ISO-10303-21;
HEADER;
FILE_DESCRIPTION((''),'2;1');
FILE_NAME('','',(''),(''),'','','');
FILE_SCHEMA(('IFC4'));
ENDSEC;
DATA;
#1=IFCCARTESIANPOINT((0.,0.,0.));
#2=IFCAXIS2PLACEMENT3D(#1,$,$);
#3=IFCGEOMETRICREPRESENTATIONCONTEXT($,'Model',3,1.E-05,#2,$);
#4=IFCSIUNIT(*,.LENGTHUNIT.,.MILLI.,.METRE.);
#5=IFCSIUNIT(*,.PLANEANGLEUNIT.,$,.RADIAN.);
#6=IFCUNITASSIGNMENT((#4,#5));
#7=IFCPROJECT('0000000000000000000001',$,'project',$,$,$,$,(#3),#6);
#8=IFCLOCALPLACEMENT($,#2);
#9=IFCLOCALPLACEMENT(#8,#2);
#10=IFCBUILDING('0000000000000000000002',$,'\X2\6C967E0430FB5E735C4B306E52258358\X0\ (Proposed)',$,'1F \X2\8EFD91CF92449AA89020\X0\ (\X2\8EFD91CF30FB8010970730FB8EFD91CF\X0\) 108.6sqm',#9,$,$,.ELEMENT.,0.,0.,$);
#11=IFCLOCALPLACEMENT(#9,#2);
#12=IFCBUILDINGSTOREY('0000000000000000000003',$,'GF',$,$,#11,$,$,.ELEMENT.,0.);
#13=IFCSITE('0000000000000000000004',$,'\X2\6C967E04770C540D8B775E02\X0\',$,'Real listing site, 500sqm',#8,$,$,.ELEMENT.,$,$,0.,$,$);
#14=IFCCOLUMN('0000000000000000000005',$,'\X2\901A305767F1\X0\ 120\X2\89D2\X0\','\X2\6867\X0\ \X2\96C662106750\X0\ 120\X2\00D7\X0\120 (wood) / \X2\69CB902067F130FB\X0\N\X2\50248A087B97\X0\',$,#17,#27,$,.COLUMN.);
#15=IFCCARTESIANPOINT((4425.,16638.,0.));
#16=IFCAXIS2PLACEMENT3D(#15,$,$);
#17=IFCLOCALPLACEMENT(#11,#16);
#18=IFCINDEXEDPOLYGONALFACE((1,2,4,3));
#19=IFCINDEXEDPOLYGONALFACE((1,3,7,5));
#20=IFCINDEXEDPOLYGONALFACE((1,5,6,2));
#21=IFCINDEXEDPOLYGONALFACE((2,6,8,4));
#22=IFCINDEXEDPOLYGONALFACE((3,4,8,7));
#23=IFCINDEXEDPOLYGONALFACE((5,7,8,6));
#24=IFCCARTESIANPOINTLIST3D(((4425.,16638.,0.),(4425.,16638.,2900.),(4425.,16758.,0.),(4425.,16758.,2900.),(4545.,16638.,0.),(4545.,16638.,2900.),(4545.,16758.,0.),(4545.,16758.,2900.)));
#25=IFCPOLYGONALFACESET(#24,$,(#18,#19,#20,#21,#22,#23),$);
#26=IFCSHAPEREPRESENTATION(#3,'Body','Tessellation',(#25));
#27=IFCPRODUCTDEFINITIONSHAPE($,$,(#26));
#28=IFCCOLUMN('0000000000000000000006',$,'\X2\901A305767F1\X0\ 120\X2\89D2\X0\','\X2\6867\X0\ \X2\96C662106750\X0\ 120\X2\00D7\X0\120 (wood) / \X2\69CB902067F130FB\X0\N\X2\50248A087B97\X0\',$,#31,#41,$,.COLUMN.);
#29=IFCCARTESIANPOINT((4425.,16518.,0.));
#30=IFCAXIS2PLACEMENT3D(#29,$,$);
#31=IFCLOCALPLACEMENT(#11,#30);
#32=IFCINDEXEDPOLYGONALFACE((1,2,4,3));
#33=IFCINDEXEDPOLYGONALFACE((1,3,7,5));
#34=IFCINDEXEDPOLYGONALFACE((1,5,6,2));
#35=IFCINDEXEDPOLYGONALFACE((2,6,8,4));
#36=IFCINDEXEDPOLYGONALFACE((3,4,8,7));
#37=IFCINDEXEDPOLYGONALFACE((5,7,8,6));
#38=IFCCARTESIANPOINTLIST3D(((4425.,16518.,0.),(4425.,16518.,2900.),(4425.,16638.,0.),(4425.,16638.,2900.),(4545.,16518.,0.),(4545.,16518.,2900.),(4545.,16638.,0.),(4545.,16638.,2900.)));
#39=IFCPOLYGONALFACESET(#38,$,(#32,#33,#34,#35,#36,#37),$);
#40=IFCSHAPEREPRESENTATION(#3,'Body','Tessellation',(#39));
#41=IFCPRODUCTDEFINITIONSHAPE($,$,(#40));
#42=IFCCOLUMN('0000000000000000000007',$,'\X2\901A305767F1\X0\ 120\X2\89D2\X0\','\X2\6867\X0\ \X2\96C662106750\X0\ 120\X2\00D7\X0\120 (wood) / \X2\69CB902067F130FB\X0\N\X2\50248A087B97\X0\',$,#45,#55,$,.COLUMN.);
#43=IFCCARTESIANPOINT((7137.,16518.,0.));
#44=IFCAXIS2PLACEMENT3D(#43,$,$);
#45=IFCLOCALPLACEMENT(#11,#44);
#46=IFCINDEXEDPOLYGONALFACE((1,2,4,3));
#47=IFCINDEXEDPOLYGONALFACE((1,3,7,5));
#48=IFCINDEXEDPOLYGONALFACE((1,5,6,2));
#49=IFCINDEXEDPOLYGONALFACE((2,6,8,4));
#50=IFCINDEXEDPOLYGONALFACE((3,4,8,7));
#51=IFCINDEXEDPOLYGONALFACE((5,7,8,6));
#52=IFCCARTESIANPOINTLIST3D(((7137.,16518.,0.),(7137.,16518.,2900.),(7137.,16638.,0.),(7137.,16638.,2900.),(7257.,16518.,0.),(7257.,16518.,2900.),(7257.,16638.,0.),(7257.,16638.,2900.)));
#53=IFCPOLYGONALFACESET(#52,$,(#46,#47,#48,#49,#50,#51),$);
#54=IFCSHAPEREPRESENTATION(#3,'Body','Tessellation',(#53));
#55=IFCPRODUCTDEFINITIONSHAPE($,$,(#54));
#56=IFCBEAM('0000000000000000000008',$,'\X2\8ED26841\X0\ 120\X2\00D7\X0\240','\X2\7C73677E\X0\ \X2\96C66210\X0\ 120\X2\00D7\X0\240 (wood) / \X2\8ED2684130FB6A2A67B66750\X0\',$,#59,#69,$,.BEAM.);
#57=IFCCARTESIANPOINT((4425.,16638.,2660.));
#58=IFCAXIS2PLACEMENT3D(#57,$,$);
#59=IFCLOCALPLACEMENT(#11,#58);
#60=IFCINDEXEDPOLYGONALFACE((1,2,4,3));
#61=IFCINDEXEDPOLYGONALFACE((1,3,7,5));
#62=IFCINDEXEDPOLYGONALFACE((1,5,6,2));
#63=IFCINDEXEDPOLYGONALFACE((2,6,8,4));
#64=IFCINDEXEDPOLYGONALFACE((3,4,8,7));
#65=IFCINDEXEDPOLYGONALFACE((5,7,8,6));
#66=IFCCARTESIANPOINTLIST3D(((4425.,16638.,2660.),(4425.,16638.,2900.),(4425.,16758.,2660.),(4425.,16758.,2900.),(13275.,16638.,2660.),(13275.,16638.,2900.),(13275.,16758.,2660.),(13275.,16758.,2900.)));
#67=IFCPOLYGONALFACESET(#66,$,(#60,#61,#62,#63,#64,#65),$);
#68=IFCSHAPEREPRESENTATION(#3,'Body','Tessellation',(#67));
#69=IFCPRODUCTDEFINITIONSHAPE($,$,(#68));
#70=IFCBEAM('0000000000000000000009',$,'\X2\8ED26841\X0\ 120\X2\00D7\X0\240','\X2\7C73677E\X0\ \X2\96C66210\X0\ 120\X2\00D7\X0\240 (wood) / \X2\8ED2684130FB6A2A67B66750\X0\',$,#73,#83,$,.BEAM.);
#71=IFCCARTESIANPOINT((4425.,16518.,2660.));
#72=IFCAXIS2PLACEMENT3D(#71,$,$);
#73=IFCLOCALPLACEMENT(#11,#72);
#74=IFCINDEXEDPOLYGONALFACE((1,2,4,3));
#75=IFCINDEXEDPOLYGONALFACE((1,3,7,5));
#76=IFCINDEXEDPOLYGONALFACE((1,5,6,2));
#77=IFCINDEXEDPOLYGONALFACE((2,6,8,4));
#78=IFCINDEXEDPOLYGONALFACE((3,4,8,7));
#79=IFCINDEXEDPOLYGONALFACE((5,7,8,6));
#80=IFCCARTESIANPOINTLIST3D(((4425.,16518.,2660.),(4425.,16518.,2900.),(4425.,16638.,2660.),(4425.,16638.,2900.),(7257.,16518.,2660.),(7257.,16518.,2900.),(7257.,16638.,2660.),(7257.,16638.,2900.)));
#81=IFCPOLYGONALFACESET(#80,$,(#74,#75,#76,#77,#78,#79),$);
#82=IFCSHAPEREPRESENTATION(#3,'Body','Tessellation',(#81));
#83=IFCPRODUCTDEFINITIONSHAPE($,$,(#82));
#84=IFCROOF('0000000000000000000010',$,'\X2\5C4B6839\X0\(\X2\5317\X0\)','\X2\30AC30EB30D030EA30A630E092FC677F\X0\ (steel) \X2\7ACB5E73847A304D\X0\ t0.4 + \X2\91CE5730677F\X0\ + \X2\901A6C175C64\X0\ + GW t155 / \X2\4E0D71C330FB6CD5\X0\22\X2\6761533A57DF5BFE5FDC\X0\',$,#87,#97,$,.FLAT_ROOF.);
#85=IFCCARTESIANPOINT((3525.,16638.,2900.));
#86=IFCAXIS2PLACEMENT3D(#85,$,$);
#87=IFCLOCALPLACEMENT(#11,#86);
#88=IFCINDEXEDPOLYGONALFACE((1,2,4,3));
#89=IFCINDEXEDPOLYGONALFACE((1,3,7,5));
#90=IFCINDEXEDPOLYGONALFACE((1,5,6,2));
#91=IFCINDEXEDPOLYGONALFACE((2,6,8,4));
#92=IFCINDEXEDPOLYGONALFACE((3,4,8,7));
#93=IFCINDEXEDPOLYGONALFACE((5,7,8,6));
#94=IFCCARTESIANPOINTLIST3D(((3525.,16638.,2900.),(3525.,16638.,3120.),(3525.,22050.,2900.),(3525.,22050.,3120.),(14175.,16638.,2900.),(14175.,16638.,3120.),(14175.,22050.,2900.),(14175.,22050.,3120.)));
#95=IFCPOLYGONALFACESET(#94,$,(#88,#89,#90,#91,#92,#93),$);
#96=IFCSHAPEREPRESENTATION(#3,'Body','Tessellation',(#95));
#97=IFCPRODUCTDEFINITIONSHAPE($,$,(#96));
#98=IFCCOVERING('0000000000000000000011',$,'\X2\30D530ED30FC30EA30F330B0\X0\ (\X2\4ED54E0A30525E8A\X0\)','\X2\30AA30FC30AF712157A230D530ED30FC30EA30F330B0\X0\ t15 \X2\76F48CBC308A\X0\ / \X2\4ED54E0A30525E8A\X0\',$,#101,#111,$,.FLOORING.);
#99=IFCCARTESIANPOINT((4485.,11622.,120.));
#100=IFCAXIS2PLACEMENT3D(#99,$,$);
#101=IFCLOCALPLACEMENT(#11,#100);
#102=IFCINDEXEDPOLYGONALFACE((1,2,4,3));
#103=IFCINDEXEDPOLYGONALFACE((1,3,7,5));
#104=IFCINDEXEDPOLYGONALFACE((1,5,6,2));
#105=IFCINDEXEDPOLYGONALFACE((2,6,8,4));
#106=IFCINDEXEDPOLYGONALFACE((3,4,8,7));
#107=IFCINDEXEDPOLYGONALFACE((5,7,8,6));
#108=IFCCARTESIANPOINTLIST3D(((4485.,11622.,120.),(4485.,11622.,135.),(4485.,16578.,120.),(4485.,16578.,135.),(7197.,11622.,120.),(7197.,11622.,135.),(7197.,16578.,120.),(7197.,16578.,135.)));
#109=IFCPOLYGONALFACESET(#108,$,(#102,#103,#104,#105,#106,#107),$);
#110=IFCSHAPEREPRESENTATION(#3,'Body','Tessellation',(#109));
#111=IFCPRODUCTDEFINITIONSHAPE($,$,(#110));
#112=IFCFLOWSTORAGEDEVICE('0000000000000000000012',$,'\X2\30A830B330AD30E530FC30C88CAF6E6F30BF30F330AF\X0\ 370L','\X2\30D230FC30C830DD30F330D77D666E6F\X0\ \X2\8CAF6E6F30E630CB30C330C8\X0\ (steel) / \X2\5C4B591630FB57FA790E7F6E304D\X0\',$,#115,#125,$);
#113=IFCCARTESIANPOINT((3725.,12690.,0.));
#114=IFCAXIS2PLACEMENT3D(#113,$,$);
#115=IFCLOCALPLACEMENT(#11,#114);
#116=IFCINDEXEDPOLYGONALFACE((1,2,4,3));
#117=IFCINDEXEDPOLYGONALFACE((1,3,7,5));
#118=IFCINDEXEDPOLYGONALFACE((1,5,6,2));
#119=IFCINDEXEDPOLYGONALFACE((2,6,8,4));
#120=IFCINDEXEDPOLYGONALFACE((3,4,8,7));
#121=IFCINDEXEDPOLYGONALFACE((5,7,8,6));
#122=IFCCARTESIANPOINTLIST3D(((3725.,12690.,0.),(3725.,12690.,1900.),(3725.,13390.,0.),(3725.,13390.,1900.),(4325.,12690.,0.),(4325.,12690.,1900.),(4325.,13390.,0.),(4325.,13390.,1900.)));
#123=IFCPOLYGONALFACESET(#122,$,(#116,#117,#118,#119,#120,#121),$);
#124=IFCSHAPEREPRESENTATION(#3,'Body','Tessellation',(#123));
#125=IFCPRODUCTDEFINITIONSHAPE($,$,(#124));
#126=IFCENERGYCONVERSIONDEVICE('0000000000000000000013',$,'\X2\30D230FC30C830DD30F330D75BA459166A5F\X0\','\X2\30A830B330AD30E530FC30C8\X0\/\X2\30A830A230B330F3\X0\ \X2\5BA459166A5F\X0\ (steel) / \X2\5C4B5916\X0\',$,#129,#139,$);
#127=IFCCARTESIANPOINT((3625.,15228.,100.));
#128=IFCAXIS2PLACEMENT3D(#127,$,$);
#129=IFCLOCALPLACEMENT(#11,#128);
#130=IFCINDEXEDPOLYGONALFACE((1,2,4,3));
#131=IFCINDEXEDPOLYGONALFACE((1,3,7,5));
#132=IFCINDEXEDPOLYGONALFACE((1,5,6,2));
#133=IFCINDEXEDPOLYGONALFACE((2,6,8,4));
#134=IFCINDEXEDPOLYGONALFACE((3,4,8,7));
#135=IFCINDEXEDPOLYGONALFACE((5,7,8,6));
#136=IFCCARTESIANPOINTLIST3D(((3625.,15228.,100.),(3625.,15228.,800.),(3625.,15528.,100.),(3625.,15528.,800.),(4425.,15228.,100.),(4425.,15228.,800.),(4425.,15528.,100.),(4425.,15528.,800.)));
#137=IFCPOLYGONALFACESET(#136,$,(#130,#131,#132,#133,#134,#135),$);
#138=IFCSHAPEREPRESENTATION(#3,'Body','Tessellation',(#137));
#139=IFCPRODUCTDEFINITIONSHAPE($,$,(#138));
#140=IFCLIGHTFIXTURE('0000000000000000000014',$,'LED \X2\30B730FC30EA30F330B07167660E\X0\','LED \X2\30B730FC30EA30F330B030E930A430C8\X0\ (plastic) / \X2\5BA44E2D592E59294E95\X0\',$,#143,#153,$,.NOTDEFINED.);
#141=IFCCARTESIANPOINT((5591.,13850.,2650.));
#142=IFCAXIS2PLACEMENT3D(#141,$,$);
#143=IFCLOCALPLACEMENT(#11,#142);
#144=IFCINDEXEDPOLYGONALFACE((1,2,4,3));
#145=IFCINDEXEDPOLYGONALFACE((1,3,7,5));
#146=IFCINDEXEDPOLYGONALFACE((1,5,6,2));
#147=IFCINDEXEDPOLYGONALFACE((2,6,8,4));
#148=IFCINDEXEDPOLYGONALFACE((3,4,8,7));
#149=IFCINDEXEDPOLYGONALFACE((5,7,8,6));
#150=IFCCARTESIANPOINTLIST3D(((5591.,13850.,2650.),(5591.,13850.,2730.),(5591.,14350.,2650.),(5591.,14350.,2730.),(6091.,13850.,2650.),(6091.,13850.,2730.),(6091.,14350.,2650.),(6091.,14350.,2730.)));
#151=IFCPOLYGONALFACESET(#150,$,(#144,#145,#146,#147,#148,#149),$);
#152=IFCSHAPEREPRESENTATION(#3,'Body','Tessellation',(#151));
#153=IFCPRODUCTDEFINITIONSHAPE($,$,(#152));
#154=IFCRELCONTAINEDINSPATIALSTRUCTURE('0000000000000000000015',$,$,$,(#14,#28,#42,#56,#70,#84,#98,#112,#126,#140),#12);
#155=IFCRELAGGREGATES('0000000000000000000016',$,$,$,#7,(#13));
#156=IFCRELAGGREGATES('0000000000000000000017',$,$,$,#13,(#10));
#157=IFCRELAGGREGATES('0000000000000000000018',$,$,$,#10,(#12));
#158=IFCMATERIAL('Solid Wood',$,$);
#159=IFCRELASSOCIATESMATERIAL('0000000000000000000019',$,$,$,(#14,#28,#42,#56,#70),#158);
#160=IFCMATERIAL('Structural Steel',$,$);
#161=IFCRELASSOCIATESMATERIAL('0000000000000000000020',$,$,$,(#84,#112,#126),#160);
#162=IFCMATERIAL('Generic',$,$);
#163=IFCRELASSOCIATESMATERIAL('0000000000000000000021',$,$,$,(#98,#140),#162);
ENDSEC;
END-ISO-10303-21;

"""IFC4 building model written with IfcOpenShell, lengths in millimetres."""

from ifc_helpers import new_model, si_unit, frame, frame_2d, origin, place, context, project, spatial, rectangle, extrude, material, element, save


model = new_model("IFC4")

# Units and contexts
model_context = context("Model", 3, precision=1e-05, world=origin())
ifc_project = project(units=[si_unit("LENGTHUNIT", "METRE", prefix="MILLI"), si_unit("PLANEANGLEUNIT", "RADIAN")], contexts=[model_context])

# Site, building, storey
site_placement = place(None, origin())
site = spatial("IfcSite", under=ifc_project, at=site_placement, Name="沖縄県名護市", ObjectType="Real listing site, 500sqm", CompositionType="ELEMENT", RefElevation=0.0)
building_placement = place(site_placement, origin())
building = spatial("IfcBuilding", under=site, at=building_placement, Name="沖縄・平屋の別荘 (Proposed)", ObjectType="1F 軽量鉄骨造 (軽量・耐震・軽量) 108.6sqm", CompositionType="ELEMENT", ElevationOfRefHeight=0.0, ElevationOfTerrain=0.0)
storey_placement = place(building_placement, origin())
storey = spatial("IfcBuildingStorey", under=building, at=storey_placement, Name="GF", CompositionType="ELEMENT", Elevation=0.0)

# Columns
ifc_material_1 = material(Name="Solid Wood")
column_1_placement = place(storey_placement, frame((4425.0, 16638.0, 0.0)))
element("IfcColumn", 1, at=column_1_placement, inside=storey, material=ifc_material_1, Name="通し柱 120角", Description="桧 集成材 120×120 (wood) / 構造柱・N値計算", PredefinedType="COLUMN", context=model_context, shape_type="SweptSolid", body=[
    extrude(rectangle(XDim=120.0, YDim=120.0, at=frame_2d((60.0, 60.0))), frame((4425.0, 16638.0, 0.0)), (0.0, 0.0, 1.0), 2900.0),
])
column_2_placement = place(storey_placement, frame((4425.0, 16518.0, 0.0)))
element("IfcColumn", 2, at=column_2_placement, inside=storey, material=ifc_material_1, Name="通し柱 120角", Description="桧 集成材 120×120 (wood) / 構造柱・N値計算", PredefinedType="COLUMN", context=model_context, shape_type="SweptSolid", body=[
    extrude(rectangle(XDim=120.0, YDim=120.0, at=frame_2d((60.0, 60.0))), frame((4425.0, 16518.0, 0.0)), (0.0, 0.0, 1.0), 2900.0),
])
column_3_placement = place(storey_placement, frame((7137.0, 16518.0, 0.0)))
element("IfcColumn", 3, at=column_3_placement, inside=storey, material=ifc_material_1, Name="通し柱 120角", Description="桧 集成材 120×120 (wood) / 構造柱・N値計算", PredefinedType="COLUMN", context=model_context, shape_type="SweptSolid", body=[
    extrude(rectangle(XDim=120.0, YDim=120.0, at=frame_2d((60.0, 60.0))), frame((7137.0, 16518.0, 0.0)), (0.0, 0.0, 1.0), 2900.0),
])

# Beams
beam_1_placement = place(storey_placement, frame((4425.0, 16638.0, 2660.0)))
element("IfcBeam", 4, at=beam_1_placement, inside=storey, material=ifc_material_1, Name="軒桁 120×240", Description="米松 集成 120×240 (wood) / 軒桁・横架材", PredefinedType="BEAM", context=model_context, shape_type="SweptSolid", body=[
    extrude(rectangle(XDim=8850.0, YDim=120.0, at=frame_2d((4425.0, 60.0))), frame((4425.0, 16638.0, 2660.0)), (0.0, 0.0, 1.0), 240.0),
])
beam_2_placement = place(storey_placement, frame((4425.0, 16518.0, 2660.0)))
element("IfcBeam", 5, at=beam_2_placement, inside=storey, material=ifc_material_1, Name="軒桁 120×240", Description="米松 集成 120×240 (wood) / 軒桁・横架材", PredefinedType="BEAM", context=model_context, shape_type="SweptSolid", body=[
    extrude(rectangle(XDim=2832.0, YDim=120.0, at=frame_2d((1416.0, 60.0))), frame((4425.0, 16518.0, 2660.0)), (0.0, 0.0, 1.0), 240.0),
])

# Roof
ifc_material_2 = material(Name="Structural Steel")
roof_placement = place(storey_placement, frame((3525.0, 16638.0, 2900.0)))
element("IfcRoof", 6, at=roof_placement, inside=storey, material=ifc_material_2, Name="屋根(北)", Description="ガルバリウム鋼板 (steel) 立平葺き t0.4 + 野地板 + 通気層 + GW t155 / 不燃・法22条区域対応", PredefinedType="FLAT_ROOF", context=model_context, shape_type="SweptSolid", body=[
    extrude(rectangle(XDim=10650.0, YDim=5412.0, at=frame_2d((5325.0, 2706.0))), frame((3525.0, 16638.0, 2900.0)), (0.0, 0.0, 1.0), 220.0),
])

# Covering
ifc_material_3 = material(Name="Generic")
covering_placement = place(storey_placement, frame((4485.0, 11622.0, 120.0)))
element("IfcCovering", 7, at=covering_placement, inside=storey, material=ifc_material_3, Name="フローリング (仕上げ床)", Description="オーク無垢フローリング t15 直貼り / 仕上げ床", PredefinedType="FLOORING", context=model_context, shape_type="SweptSolid", body=[
    extrude(rectangle(XDim=2712.0, YDim=4956.0, at=frame_2d((1356.0, 2478.0))), frame((4485.0, 11622.0, 120.0)), (0.0, 0.0, 1.0), 15.0),
])

# Flow storage device
flow_storage_device_placement = place(storey_placement, frame((3725.0, 12690.0, 0.0)))
element("IfcFlowStorageDevice", 8, at=flow_storage_device_placement, inside=storey, material=ifc_material_2, Name="エコキュート貯湯タンク 370L", Description="ヒートポンプ給湯 貯湯ユニット (steel) / 屋外・基礎置き", context=model_context, shape_type="SweptSolid", body=[
    extrude(rectangle(XDim=600.0, YDim=700.0, at=frame_2d((300.0, 350.0))), frame((3725.0, 12690.0, 0.0)), (0.0, 0.0, 1.0), 1900.0),
])

# Energy conversion device
energy_conversion_device_placement = place(storey_placement, frame((3625.0, 15228.0, 100.0)))
element("IfcEnergyConversionDevice", 9, at=energy_conversion_device_placement, inside=storey, material=ifc_material_2, Name="ヒートポンプ室外機", Description="エコキュート/エアコン 室外機 (steel) / 屋外", context=model_context, shape_type="SweptSolid", body=[
    extrude(rectangle(XDim=800.0, YDim=300.0, at=frame_2d((400.0, 150.0))), frame((3625.0, 15228.0, 100.0)), (0.0, 0.0, 1.0), 700.0),
])

# Light fixture
light_fixture_placement = place(storey_placement, frame((5591.0, 13850.0, 2650.0)))
element("IfcLightFixture", 10, at=light_fixture_placement, inside=storey, material=ifc_material_3, Name="LED シーリング照明", Description="LED シーリングライト (plastic) / 室中央天井", PredefinedType="NOTDEFINED", context=model_context, shape_type="SweptSolid", body=[
    extrude(rectangle(XDim=500.0, YDim=500.0, at=frame_2d((250.0, 250.0))), frame((5591.0, 13850.0, 2650.0)), (0.0, 0.0, 1.0), 80.0),
])

save(model, "model.ifc")
